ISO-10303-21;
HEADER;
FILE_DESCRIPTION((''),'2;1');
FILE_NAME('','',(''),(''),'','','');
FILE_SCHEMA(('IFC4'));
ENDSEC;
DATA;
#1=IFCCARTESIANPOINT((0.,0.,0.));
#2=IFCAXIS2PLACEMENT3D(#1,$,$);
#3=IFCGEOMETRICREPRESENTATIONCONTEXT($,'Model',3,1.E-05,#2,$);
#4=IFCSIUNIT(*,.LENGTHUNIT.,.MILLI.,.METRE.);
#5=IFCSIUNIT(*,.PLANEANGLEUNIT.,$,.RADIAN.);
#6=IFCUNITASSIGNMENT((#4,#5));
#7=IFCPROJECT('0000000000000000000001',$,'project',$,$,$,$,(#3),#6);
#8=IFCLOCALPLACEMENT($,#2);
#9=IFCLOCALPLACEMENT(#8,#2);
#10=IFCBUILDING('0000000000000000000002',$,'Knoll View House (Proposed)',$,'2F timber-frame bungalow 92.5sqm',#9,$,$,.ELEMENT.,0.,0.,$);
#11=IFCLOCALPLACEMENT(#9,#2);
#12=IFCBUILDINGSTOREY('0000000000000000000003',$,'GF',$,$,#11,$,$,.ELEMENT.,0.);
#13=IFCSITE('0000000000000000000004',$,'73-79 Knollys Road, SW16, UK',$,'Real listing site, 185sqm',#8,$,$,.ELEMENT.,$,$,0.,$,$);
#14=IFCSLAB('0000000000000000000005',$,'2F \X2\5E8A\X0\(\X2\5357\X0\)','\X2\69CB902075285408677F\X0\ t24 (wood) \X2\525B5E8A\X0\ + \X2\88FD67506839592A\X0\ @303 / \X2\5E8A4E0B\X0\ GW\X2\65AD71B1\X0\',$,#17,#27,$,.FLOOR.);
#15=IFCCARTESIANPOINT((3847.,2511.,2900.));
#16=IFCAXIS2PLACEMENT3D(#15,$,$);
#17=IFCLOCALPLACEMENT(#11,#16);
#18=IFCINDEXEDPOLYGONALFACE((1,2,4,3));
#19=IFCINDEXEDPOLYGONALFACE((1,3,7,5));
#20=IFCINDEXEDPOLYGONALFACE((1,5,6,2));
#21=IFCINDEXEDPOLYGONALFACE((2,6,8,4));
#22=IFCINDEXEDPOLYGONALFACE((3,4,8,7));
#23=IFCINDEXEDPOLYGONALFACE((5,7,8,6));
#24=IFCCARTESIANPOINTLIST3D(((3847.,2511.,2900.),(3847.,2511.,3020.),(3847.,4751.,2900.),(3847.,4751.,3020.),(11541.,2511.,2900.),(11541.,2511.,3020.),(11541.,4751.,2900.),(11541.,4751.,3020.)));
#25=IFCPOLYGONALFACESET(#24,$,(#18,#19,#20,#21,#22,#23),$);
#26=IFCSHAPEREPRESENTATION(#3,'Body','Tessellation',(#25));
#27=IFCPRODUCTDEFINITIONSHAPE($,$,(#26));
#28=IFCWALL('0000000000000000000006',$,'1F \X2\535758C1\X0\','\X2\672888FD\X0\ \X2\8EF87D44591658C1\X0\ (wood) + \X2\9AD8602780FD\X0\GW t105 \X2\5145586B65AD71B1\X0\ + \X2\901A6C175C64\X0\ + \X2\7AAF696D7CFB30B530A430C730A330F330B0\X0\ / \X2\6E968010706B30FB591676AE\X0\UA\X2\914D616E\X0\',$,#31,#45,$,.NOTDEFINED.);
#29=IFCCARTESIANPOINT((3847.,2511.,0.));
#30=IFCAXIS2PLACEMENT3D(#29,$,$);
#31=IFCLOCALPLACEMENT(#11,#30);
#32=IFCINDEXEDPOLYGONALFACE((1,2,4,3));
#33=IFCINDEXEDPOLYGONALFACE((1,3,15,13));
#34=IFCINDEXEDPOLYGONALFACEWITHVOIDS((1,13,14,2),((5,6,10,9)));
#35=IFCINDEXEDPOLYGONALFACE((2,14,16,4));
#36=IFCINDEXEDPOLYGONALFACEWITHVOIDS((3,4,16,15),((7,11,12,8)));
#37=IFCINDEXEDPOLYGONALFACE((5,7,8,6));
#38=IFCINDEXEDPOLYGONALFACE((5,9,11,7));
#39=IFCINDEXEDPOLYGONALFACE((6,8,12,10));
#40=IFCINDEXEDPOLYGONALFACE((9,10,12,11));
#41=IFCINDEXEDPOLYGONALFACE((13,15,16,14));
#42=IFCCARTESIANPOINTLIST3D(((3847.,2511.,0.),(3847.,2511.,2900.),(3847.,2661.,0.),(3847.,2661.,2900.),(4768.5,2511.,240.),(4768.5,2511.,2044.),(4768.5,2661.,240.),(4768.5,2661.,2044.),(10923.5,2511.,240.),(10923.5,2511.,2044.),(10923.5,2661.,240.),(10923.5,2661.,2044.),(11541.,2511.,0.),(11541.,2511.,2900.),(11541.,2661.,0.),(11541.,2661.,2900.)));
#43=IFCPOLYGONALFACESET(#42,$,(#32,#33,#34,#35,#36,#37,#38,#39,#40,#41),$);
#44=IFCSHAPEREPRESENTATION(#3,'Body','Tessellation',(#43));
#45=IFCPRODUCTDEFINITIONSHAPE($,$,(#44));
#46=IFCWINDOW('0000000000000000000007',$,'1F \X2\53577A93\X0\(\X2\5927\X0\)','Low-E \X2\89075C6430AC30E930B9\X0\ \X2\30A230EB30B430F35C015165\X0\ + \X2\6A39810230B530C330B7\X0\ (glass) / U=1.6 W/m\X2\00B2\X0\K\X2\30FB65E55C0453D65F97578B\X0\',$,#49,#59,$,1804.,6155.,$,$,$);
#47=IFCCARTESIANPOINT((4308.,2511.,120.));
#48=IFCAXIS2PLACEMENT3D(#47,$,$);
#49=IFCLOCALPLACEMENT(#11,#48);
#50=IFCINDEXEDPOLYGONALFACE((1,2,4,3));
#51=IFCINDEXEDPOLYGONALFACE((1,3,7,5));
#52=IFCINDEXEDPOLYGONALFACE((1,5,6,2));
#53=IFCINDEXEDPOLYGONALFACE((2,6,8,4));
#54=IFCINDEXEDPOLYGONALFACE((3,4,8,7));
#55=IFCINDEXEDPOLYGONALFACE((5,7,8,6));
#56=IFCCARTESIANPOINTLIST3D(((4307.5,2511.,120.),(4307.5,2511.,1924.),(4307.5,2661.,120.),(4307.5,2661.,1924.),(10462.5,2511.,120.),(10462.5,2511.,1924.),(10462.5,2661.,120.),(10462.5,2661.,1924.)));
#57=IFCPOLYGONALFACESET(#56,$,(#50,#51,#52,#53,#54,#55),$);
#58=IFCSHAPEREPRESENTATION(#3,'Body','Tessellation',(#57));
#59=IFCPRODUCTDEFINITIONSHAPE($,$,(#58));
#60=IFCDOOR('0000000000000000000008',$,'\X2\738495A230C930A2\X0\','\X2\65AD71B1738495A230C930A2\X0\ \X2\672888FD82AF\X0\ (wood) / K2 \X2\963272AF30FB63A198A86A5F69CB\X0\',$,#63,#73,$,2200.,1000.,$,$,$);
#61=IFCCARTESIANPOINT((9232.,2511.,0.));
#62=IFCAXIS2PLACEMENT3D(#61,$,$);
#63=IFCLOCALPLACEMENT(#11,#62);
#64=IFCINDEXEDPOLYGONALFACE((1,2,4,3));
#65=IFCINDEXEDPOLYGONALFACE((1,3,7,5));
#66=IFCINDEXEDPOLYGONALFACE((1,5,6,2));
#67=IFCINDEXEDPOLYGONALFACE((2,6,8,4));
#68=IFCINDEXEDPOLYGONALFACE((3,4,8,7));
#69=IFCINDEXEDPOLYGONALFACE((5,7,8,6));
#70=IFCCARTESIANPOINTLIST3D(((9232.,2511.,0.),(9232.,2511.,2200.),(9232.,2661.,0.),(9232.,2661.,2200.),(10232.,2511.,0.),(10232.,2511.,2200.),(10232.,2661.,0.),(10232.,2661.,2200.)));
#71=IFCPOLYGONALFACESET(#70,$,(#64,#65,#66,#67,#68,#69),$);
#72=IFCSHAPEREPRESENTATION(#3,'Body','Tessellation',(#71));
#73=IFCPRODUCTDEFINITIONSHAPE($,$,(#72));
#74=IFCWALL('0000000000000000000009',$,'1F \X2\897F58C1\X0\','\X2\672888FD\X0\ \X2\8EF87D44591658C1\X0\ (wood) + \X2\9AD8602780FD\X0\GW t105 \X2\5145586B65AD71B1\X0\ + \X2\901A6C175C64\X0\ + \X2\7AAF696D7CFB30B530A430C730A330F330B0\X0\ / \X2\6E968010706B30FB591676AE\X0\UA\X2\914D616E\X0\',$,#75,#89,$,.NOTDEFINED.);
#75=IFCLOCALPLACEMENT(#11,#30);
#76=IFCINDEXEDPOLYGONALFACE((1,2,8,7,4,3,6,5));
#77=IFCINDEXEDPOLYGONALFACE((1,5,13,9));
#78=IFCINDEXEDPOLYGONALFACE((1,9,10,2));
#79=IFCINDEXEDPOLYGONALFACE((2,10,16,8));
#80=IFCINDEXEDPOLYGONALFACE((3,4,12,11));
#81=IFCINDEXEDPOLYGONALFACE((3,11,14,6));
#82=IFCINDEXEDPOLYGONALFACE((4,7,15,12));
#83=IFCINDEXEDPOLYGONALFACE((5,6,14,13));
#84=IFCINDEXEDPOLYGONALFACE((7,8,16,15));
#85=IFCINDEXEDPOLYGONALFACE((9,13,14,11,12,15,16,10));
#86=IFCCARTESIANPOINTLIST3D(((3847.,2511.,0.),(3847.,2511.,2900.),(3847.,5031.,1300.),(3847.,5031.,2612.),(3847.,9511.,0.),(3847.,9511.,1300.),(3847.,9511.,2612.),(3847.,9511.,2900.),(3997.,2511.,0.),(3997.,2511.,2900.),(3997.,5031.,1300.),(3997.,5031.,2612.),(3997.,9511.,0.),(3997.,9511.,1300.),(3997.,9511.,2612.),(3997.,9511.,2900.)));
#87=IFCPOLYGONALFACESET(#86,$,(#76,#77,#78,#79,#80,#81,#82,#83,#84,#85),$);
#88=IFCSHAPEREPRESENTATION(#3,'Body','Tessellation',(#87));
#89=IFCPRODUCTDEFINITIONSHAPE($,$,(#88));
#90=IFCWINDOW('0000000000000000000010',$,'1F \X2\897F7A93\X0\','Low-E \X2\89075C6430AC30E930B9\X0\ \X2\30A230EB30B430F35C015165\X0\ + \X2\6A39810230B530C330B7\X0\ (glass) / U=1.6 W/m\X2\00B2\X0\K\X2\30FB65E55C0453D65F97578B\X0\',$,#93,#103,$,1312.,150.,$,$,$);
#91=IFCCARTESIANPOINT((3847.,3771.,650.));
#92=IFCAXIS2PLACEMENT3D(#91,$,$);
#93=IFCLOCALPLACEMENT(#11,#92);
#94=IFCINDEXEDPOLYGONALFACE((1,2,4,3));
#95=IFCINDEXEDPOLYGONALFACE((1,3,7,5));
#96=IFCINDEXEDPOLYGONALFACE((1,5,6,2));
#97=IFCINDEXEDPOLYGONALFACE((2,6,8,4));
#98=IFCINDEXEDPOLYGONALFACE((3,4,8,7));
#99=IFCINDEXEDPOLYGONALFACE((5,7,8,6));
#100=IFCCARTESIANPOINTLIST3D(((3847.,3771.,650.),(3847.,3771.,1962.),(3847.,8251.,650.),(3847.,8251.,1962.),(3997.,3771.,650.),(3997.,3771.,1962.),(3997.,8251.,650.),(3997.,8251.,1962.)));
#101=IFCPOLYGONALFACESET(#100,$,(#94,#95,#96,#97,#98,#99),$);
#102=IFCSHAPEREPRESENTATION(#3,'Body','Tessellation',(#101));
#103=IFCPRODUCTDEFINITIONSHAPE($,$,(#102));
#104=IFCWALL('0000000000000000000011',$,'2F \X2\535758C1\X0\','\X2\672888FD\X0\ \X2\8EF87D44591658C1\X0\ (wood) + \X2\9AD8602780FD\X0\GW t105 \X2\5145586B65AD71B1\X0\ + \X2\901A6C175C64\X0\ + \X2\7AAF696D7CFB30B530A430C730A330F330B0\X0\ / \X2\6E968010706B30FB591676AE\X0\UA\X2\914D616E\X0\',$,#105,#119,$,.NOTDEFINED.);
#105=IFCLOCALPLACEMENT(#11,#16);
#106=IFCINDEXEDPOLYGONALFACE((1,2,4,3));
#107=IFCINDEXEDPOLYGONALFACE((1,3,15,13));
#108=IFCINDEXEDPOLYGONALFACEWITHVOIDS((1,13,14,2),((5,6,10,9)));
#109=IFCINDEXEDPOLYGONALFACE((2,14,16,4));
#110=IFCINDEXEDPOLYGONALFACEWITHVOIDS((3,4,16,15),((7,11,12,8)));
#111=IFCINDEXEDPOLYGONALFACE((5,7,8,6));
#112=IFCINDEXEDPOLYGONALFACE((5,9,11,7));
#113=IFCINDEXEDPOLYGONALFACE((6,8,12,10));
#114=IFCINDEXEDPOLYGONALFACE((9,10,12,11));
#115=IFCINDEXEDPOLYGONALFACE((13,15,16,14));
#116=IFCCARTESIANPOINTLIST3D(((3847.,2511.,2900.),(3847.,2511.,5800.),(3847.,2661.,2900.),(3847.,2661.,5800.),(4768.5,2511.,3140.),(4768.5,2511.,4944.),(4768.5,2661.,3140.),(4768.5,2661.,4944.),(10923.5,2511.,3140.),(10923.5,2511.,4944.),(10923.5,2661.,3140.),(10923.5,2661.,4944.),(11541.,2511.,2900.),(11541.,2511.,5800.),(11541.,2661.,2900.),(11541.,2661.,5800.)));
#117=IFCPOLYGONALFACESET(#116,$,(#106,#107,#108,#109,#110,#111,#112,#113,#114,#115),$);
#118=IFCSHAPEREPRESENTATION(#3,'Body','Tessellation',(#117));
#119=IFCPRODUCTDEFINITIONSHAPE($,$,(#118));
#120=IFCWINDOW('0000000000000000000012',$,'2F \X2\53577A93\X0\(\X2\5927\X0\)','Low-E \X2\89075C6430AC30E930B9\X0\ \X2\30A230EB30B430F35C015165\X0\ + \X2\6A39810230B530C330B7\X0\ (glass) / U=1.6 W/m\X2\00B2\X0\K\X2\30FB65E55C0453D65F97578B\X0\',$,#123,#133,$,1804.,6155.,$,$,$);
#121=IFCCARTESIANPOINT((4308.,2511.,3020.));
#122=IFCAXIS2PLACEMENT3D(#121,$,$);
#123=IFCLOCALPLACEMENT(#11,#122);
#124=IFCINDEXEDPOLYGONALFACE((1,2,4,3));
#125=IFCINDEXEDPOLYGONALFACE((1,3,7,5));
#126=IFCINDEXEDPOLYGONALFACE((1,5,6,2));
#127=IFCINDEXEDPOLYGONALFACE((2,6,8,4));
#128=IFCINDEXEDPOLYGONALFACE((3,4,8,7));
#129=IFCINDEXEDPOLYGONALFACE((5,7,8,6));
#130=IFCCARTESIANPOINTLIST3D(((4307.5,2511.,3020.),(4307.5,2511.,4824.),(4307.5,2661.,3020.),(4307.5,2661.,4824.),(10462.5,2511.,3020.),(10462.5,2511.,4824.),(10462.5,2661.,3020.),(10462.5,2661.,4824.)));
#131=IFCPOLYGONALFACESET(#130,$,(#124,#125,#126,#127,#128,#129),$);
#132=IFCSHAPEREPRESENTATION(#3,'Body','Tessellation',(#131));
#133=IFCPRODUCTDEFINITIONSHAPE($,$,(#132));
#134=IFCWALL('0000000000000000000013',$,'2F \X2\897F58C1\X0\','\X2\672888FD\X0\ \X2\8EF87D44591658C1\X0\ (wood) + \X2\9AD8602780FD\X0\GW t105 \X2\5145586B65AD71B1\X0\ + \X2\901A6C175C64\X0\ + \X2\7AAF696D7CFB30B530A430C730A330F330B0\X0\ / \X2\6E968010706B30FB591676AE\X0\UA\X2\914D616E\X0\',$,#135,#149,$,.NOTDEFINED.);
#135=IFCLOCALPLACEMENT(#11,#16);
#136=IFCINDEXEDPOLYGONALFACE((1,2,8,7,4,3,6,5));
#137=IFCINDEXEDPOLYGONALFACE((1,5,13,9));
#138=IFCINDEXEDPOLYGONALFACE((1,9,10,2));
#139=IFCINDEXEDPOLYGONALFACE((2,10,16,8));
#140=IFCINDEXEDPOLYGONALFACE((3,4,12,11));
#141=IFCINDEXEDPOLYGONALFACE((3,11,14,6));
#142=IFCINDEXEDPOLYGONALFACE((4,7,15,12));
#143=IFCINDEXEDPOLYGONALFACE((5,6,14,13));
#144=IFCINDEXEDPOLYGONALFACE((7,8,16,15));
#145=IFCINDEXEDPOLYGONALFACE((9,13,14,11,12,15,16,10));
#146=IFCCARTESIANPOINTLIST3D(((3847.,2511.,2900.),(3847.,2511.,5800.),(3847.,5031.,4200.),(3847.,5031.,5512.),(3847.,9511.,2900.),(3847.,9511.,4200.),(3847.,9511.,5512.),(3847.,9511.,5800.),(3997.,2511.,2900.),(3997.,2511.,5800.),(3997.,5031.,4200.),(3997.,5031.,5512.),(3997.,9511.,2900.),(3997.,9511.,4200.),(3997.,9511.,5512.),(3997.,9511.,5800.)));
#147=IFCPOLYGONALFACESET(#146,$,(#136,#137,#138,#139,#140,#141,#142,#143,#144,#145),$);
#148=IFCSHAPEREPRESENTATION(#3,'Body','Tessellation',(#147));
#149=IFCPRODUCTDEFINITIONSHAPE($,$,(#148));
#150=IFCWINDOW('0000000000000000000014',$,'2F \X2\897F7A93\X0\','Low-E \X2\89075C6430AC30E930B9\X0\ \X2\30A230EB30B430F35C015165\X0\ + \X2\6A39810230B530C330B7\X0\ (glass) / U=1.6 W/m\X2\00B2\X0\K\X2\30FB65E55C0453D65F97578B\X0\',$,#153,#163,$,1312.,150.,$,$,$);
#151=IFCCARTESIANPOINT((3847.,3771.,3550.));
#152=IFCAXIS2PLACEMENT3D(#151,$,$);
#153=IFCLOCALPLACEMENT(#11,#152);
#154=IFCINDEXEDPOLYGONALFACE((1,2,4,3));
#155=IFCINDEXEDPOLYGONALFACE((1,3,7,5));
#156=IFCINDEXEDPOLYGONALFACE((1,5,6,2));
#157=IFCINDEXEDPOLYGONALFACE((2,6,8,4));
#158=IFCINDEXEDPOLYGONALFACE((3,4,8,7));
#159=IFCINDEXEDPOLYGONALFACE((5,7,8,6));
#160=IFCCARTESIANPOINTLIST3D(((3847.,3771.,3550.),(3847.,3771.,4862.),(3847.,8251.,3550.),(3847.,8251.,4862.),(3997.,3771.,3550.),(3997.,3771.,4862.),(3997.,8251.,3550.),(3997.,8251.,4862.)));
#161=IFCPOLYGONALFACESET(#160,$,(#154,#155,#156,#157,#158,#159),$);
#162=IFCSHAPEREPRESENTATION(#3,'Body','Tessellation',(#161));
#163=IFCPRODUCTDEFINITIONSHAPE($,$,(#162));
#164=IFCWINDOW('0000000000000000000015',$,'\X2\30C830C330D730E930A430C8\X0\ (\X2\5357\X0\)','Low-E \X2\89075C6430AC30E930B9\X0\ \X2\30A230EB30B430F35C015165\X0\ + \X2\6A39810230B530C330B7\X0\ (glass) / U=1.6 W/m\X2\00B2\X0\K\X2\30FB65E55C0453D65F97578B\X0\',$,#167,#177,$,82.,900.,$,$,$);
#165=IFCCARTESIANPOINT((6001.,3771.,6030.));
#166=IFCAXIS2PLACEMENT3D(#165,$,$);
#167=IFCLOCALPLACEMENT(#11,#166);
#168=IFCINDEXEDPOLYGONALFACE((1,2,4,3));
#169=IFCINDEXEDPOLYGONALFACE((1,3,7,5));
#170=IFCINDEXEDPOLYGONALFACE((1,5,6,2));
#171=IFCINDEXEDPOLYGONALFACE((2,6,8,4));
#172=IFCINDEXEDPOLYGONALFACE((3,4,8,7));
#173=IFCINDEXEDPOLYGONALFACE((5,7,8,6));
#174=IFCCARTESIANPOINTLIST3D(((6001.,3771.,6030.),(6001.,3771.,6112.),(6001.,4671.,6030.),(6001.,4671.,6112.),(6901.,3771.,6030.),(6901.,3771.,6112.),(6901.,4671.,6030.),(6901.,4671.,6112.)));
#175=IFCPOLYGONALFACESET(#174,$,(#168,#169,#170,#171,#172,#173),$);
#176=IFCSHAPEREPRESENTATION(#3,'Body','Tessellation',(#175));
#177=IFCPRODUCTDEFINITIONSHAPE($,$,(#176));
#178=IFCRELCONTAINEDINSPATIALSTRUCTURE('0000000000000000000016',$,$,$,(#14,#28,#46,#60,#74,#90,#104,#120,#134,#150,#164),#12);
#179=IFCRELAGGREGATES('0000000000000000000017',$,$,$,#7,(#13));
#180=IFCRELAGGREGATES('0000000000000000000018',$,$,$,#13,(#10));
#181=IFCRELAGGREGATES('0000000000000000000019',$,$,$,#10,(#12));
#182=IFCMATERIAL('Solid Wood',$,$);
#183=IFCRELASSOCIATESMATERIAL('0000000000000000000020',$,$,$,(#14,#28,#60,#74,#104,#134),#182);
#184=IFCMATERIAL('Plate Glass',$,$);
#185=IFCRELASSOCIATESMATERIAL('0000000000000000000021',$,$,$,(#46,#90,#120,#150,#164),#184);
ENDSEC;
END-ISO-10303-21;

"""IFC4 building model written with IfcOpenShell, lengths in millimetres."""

from ifc_helpers import new_model, si_unit, frame, frame_2d, origin, place, context, project, spatial, rectangle, extrude, material, element, fill, save


model = new_model("IFC4")

# Units and contexts
model_context = context("Model", 3, precision=1e-05, world=origin())
ifc_project = project(units=[si_unit("LENGTHUNIT", "METRE", prefix="MILLI"), si_unit("PLANEANGLEUNIT", "RADIAN")], contexts=[model_context])

# Site, building, storey
site_placement = place(None, origin())
site = spatial("IfcSite", under=ifc_project, at=site_placement, Name="73-79 Knollys Road, SW16, UK", ObjectType="Real listing site, 185sqm", CompositionType="ELEMENT", RefElevation=0.0)
building_placement = place(site_placement, origin())
building = spatial("IfcBuilding", under=site, at=building_placement, Name="Knoll View House (Proposed)", ObjectType="2F timber-frame bungalow 92.5sqm", CompositionType="ELEMENT", ElevationOfRefHeight=0.0, ElevationOfTerrain=0.0)
storey_placement = place(building_placement, origin())
storey = spatial("IfcBuildingStorey", under=building, at=storey_placement, Name="GF", CompositionType="ELEMENT", Elevation=0.0)

# Slab
ifc_material_1 = material(Name="Solid Wood")
slab_1_placement = place(storey_placement, frame((3847.0, 2511.0, 2900.0)))
element("IfcSlab", 1, at=slab_1_placement, inside=storey, material=ifc_material_1, Name="2F 床(南)", Description="構造用合板 t24 (wood) 剛床 + 製材根太 @303 / 床下 GW断熱", PredefinedType="FLOOR", context=model_context, shape_type="SweptSolid", body=[
    extrude(rectangle(XDim=7694.0, YDim=2240.0, at=frame_2d((3847.0, 1120.0))), frame((3847.0, 2511.0, 2900.0)), (0.0, 0.0, 1.0), 120.0),
])

# Wall, openings, window, door
wall_1_placement = place(storey_placement, frame((3847.0, 2511.0, 0.0)))
wall_1 = element("IfcWall", 2, at=wall_1_placement, inside=storey, material=ifc_material_1, Name="1F 南壁", Description="木製 軸組外壁 (wood) + 高性能GW t105 充填断熱 + 通気層 + 窯業系サイディング / 準耐火・外皮UA配慮", PredefinedType="NOTDEFINED", context=model_context, shape_type="SweptSolid", body=[
    extrude(rectangle(XDim=7694.0, YDim=150.0, at=frame_2d((3847.0, 75.0))), frame((3847.0, 2511.0, 0.0)), (0.0, 0.0, 1.0), 2900.0),
])
opening_1_placement = place(storey_placement, frame((4308.0, 2511.0, 120.0)))
opening_1 = element("IfcOpeningElement", 3, at=opening_1_placement, cuts=wall_1, PredefinedType="NOTDEFINED", context=model_context, shape_type="SweptSolid", body=[
    extrude(rectangle(XDim=6155.0, YDim=150.0, at=frame_2d((3077.0, 75.0))), frame((4308.0, 2511.0, 120.0)), (0.0, 0.0, 1.0), 1804.0),
])
opening_2_placement = place(storey_placement, frame((9232.0, 2511.0, 0.0)))
opening_2 = element("IfcOpeningElement", 4, at=opening_2_placement, cuts=wall_1, PredefinedType="NOTDEFINED", context=model_context, shape_type="SweptSolid", body=[
    extrude(rectangle(XDim=1000.0, YDim=150.0, at=frame_2d((500.0, 75.0))), frame((9232.0, 2511.0, 0.0)), (0.0, 0.0, 1.0), 2200.0),
])
ifc_material_2 = material(Name="Plate Glass")
window_1_placement = place(storey_placement, frame((4308.0, 2511.0, 120.0)))
window_1 = element("IfcWindow", 5, at=window_1_placement, inside=storey, material=ifc_material_2, Name="1F 南窓(大)", Description="Low-E 複層ガラス アルゴン封入 + 樹脂サッシ (glass) / U=1.6 W/m²K・日射取得型", OverallHeight=1804.0, OverallWidth=6155.0, context=model_context, shape_type="SweptSolid", body=[
    extrude(rectangle(XDim=6155.0, YDim=150.0, at=frame_2d((3077.0, 75.0))), frame((4308.0, 2511.0, 120.0)), (0.0, 0.0, 1.0), 1804.0),
])
fill(opening_1, window_1)
door_placement = place(storey_placement, frame((9232.0, 2511.0, 0.0)))
door = element("IfcDoor", 6, at=door_placement, inside=storey, material=ifc_material_1, Name="玄関ドア", Description="断熱玄関ドア 木製芯 (wood) / K2 防犯・採風機構", OverallHeight=2200.0, OverallWidth=1000.0, context=model_context, shape_type="SweptSolid", body=[
    extrude(rectangle(XDim=1000.0, YDim=150.0, at=frame_2d((500.0, 75.0))), frame((9232.0, 2511.0, 0.0)), (0.0, 0.0, 1.0), 2200.0),
])
fill(opening_2, door)

# Walls, openings, windows
wall_2_placement = place(storey_placement, frame((3847.0, 2511.0, 0.0)))
wall_2 = element("IfcWall", 7, at=wall_2_placement, inside=storey, material=ifc_material_1, Name="1F 西壁", Description="木製 軸組外壁 (wood) + 高性能GW t105 充填断熱 + 通気層 + 窯業系サイディング / 準耐火・外皮UA配慮", PredefinedType="NOTDEFINED", context=model_context, shape_type="SweptSolid", body=[
    extrude(rectangle(XDim=150.0, YDim=7000.0, at=frame_2d((75.0, 3500.0))), frame((3847.0, 2511.0, 0.0)), (0.0, 0.0, 1.0), 2900.0),
])
opening_3_placement = place(storey_placement, frame((3847.0, 3771.0, 650.0)))
opening_3 = element("IfcOpeningElement", 8, at=opening_3_placement, cuts=wall_2, PredefinedType="NOTDEFINED", context=model_context, shape_type="SweptSolid", body=[
    extrude(rectangle(XDim=150.0, YDim=4480.0, at=frame_2d((75.0, 2240.0))), frame((3847.0, 3771.0, 650.0)), (0.0, 0.0, 1.0), 1312.0),
])
window_2_placement = place(storey_placement, frame((3847.0, 3771.0, 650.0)))
window_2 = element("IfcWindow", 9, at=window_2_placement, inside=storey, material=ifc_material_2, Name="1F 西窓", Description="Low-E 複層ガラス アルゴン封入 + 樹脂サッシ (glass) / U=1.6 W/m²K・日射取得型", OverallHeight=1312.0, OverallWidth=150.0, context=model_context, shape_type="SweptSolid", body=[
    extrude(rectangle(XDim=150.0, YDim=4480.0, at=frame_2d((75.0, 2240.0))), frame((3847.0, 3771.0, 650.0)), (0.0, 0.0, 1.0), 1312.0),
])
fill(opening_3, window_2)
wall_3_placement = place(storey_placement, frame((3847.0, 2511.0, 2900.0)))
wall_3 = element("IfcWall", 10, at=wall_3_placement, inside=storey, material=ifc_material_1, Name="2F 南壁", Description="木製 軸組外壁 (wood) + 高性能GW t105 充填断熱 + 通気層 + 窯業系サイディング / 準耐火・外皮UA配慮", PredefinedType="NOTDEFINED", context=model_context, shape_type="SweptSolid", body=[
    extrude(rectangle(XDim=7694.0, YDim=150.0, at=frame_2d((3847.0, 75.0))), frame((3847.0, 2511.0, 2900.0)), (0.0, 0.0, 1.0), 2900.0),
])
opening_4_placement = place(storey_placement, frame((4308.0, 2511.0, 3020.0)))
opening_4 = element("IfcOpeningElement", 11, at=opening_4_placement, cuts=wall_3, PredefinedType="NOTDEFINED", context=model_context, shape_type="SweptSolid", body=[
    extrude(rectangle(XDim=6155.0, YDim=150.0, at=frame_2d((3077.0, 75.0))), frame((4308.0, 2511.0, 3020.0)), (0.0, 0.0, 1.0), 1804.0),
])
window_3_placement = place(storey_placement, frame((4308.0, 2511.0, 3020.0)))
window_3 = element("IfcWindow", 12, at=window_3_placement, inside=storey, material=ifc_material_2, Name="2F 南窓(大)", Description="Low-E 複層ガラス アルゴン封入 + 樹脂サッシ (glass) / U=1.6 W/m²K・日射取得型", OverallHeight=1804.0, OverallWidth=6155.0, context=model_context, shape_type="SweptSolid", body=[
    extrude(rectangle(XDim=6155.0, YDim=150.0, at=frame_2d((3077.0, 75.0))), frame((4308.0, 2511.0, 3020.0)), (0.0, 0.0, 1.0), 1804.0),
])
fill(opening_4, window_3)
wall_4_placement = place(storey_placement, frame((3847.0, 2511.0, 2900.0)))
wall_4 = element("IfcWall", 13, at=wall_4_placement, inside=storey, material=ifc_material_1, Name="2F 西壁", Description="木製 軸組外壁 (wood) + 高性能GW t105 充填断熱 + 通気層 + 窯業系サイディング / 準耐火・外皮UA配慮", PredefinedType="NOTDEFINED", context=model_context, shape_type="SweptSolid", body=[
    extrude(rectangle(XDim=150.0, YDim=7000.0, at=frame_2d((75.0, 3500.0))), frame((3847.0, 2511.0, 2900.0)), (0.0, 0.0, 1.0), 2900.0),
])
opening_5_placement = place(storey_placement, frame((3847.0, 3771.0, 3550.0)))
opening_5 = element("IfcOpeningElement", 14, at=opening_5_placement, cuts=wall_4, PredefinedType="NOTDEFINED", context=model_context, shape_type="SweptSolid", body=[
    extrude(rectangle(XDim=150.0, YDim=4480.0, at=frame_2d((75.0, 2240.0))), frame((3847.0, 3771.0, 3550.0)), (0.0, 0.0, 1.0), 1312.0),
])
window_4_placement = place(storey_placement, frame((3847.0, 3771.0, 3550.0)))
window_4 = element("IfcWindow", 15, at=window_4_placement, inside=storey, material=ifc_material_2, Name="2F 西窓", Description="Low-E 複層ガラス アルゴン封入 + 樹脂サッシ (glass) / U=1.6 W/m²K・日射取得型", OverallHeight=1312.0, OverallWidth=150.0, context=model_context, shape_type="SweptSolid", body=[
    extrude(rectangle(XDim=150.0, YDim=4480.0, at=frame_2d((75.0, 2240.0))), frame((3847.0, 3771.0, 3550.0)), (0.0, 0.0, 1.0), 1312.0),
])
fill(opening_5, window_4)

# Window
window_5_placement = place(storey_placement, frame((6001.0, 3771.0, 6030.0)))
element("IfcWindow", 16, at=window_5_placement, inside=storey, material=ifc_material_2, Name="トップライト (南)", Description="Low-E 複層ガラス アルゴン封入 + 樹脂サッシ (glass) / U=1.6 W/m²K・日射取得型", OverallHeight=82.0, OverallWidth=900.0, context=model_context, shape_type="SweptSolid", body=[
    extrude(rectangle(XDim=900.0, YDim=900.0, at=frame_2d((450.0, 450.0))), frame((6001.0, 3771.0, 6030.0)), (0.0, 0.0, 1.0), 82.0),
])

save(model, "model.ifc")
